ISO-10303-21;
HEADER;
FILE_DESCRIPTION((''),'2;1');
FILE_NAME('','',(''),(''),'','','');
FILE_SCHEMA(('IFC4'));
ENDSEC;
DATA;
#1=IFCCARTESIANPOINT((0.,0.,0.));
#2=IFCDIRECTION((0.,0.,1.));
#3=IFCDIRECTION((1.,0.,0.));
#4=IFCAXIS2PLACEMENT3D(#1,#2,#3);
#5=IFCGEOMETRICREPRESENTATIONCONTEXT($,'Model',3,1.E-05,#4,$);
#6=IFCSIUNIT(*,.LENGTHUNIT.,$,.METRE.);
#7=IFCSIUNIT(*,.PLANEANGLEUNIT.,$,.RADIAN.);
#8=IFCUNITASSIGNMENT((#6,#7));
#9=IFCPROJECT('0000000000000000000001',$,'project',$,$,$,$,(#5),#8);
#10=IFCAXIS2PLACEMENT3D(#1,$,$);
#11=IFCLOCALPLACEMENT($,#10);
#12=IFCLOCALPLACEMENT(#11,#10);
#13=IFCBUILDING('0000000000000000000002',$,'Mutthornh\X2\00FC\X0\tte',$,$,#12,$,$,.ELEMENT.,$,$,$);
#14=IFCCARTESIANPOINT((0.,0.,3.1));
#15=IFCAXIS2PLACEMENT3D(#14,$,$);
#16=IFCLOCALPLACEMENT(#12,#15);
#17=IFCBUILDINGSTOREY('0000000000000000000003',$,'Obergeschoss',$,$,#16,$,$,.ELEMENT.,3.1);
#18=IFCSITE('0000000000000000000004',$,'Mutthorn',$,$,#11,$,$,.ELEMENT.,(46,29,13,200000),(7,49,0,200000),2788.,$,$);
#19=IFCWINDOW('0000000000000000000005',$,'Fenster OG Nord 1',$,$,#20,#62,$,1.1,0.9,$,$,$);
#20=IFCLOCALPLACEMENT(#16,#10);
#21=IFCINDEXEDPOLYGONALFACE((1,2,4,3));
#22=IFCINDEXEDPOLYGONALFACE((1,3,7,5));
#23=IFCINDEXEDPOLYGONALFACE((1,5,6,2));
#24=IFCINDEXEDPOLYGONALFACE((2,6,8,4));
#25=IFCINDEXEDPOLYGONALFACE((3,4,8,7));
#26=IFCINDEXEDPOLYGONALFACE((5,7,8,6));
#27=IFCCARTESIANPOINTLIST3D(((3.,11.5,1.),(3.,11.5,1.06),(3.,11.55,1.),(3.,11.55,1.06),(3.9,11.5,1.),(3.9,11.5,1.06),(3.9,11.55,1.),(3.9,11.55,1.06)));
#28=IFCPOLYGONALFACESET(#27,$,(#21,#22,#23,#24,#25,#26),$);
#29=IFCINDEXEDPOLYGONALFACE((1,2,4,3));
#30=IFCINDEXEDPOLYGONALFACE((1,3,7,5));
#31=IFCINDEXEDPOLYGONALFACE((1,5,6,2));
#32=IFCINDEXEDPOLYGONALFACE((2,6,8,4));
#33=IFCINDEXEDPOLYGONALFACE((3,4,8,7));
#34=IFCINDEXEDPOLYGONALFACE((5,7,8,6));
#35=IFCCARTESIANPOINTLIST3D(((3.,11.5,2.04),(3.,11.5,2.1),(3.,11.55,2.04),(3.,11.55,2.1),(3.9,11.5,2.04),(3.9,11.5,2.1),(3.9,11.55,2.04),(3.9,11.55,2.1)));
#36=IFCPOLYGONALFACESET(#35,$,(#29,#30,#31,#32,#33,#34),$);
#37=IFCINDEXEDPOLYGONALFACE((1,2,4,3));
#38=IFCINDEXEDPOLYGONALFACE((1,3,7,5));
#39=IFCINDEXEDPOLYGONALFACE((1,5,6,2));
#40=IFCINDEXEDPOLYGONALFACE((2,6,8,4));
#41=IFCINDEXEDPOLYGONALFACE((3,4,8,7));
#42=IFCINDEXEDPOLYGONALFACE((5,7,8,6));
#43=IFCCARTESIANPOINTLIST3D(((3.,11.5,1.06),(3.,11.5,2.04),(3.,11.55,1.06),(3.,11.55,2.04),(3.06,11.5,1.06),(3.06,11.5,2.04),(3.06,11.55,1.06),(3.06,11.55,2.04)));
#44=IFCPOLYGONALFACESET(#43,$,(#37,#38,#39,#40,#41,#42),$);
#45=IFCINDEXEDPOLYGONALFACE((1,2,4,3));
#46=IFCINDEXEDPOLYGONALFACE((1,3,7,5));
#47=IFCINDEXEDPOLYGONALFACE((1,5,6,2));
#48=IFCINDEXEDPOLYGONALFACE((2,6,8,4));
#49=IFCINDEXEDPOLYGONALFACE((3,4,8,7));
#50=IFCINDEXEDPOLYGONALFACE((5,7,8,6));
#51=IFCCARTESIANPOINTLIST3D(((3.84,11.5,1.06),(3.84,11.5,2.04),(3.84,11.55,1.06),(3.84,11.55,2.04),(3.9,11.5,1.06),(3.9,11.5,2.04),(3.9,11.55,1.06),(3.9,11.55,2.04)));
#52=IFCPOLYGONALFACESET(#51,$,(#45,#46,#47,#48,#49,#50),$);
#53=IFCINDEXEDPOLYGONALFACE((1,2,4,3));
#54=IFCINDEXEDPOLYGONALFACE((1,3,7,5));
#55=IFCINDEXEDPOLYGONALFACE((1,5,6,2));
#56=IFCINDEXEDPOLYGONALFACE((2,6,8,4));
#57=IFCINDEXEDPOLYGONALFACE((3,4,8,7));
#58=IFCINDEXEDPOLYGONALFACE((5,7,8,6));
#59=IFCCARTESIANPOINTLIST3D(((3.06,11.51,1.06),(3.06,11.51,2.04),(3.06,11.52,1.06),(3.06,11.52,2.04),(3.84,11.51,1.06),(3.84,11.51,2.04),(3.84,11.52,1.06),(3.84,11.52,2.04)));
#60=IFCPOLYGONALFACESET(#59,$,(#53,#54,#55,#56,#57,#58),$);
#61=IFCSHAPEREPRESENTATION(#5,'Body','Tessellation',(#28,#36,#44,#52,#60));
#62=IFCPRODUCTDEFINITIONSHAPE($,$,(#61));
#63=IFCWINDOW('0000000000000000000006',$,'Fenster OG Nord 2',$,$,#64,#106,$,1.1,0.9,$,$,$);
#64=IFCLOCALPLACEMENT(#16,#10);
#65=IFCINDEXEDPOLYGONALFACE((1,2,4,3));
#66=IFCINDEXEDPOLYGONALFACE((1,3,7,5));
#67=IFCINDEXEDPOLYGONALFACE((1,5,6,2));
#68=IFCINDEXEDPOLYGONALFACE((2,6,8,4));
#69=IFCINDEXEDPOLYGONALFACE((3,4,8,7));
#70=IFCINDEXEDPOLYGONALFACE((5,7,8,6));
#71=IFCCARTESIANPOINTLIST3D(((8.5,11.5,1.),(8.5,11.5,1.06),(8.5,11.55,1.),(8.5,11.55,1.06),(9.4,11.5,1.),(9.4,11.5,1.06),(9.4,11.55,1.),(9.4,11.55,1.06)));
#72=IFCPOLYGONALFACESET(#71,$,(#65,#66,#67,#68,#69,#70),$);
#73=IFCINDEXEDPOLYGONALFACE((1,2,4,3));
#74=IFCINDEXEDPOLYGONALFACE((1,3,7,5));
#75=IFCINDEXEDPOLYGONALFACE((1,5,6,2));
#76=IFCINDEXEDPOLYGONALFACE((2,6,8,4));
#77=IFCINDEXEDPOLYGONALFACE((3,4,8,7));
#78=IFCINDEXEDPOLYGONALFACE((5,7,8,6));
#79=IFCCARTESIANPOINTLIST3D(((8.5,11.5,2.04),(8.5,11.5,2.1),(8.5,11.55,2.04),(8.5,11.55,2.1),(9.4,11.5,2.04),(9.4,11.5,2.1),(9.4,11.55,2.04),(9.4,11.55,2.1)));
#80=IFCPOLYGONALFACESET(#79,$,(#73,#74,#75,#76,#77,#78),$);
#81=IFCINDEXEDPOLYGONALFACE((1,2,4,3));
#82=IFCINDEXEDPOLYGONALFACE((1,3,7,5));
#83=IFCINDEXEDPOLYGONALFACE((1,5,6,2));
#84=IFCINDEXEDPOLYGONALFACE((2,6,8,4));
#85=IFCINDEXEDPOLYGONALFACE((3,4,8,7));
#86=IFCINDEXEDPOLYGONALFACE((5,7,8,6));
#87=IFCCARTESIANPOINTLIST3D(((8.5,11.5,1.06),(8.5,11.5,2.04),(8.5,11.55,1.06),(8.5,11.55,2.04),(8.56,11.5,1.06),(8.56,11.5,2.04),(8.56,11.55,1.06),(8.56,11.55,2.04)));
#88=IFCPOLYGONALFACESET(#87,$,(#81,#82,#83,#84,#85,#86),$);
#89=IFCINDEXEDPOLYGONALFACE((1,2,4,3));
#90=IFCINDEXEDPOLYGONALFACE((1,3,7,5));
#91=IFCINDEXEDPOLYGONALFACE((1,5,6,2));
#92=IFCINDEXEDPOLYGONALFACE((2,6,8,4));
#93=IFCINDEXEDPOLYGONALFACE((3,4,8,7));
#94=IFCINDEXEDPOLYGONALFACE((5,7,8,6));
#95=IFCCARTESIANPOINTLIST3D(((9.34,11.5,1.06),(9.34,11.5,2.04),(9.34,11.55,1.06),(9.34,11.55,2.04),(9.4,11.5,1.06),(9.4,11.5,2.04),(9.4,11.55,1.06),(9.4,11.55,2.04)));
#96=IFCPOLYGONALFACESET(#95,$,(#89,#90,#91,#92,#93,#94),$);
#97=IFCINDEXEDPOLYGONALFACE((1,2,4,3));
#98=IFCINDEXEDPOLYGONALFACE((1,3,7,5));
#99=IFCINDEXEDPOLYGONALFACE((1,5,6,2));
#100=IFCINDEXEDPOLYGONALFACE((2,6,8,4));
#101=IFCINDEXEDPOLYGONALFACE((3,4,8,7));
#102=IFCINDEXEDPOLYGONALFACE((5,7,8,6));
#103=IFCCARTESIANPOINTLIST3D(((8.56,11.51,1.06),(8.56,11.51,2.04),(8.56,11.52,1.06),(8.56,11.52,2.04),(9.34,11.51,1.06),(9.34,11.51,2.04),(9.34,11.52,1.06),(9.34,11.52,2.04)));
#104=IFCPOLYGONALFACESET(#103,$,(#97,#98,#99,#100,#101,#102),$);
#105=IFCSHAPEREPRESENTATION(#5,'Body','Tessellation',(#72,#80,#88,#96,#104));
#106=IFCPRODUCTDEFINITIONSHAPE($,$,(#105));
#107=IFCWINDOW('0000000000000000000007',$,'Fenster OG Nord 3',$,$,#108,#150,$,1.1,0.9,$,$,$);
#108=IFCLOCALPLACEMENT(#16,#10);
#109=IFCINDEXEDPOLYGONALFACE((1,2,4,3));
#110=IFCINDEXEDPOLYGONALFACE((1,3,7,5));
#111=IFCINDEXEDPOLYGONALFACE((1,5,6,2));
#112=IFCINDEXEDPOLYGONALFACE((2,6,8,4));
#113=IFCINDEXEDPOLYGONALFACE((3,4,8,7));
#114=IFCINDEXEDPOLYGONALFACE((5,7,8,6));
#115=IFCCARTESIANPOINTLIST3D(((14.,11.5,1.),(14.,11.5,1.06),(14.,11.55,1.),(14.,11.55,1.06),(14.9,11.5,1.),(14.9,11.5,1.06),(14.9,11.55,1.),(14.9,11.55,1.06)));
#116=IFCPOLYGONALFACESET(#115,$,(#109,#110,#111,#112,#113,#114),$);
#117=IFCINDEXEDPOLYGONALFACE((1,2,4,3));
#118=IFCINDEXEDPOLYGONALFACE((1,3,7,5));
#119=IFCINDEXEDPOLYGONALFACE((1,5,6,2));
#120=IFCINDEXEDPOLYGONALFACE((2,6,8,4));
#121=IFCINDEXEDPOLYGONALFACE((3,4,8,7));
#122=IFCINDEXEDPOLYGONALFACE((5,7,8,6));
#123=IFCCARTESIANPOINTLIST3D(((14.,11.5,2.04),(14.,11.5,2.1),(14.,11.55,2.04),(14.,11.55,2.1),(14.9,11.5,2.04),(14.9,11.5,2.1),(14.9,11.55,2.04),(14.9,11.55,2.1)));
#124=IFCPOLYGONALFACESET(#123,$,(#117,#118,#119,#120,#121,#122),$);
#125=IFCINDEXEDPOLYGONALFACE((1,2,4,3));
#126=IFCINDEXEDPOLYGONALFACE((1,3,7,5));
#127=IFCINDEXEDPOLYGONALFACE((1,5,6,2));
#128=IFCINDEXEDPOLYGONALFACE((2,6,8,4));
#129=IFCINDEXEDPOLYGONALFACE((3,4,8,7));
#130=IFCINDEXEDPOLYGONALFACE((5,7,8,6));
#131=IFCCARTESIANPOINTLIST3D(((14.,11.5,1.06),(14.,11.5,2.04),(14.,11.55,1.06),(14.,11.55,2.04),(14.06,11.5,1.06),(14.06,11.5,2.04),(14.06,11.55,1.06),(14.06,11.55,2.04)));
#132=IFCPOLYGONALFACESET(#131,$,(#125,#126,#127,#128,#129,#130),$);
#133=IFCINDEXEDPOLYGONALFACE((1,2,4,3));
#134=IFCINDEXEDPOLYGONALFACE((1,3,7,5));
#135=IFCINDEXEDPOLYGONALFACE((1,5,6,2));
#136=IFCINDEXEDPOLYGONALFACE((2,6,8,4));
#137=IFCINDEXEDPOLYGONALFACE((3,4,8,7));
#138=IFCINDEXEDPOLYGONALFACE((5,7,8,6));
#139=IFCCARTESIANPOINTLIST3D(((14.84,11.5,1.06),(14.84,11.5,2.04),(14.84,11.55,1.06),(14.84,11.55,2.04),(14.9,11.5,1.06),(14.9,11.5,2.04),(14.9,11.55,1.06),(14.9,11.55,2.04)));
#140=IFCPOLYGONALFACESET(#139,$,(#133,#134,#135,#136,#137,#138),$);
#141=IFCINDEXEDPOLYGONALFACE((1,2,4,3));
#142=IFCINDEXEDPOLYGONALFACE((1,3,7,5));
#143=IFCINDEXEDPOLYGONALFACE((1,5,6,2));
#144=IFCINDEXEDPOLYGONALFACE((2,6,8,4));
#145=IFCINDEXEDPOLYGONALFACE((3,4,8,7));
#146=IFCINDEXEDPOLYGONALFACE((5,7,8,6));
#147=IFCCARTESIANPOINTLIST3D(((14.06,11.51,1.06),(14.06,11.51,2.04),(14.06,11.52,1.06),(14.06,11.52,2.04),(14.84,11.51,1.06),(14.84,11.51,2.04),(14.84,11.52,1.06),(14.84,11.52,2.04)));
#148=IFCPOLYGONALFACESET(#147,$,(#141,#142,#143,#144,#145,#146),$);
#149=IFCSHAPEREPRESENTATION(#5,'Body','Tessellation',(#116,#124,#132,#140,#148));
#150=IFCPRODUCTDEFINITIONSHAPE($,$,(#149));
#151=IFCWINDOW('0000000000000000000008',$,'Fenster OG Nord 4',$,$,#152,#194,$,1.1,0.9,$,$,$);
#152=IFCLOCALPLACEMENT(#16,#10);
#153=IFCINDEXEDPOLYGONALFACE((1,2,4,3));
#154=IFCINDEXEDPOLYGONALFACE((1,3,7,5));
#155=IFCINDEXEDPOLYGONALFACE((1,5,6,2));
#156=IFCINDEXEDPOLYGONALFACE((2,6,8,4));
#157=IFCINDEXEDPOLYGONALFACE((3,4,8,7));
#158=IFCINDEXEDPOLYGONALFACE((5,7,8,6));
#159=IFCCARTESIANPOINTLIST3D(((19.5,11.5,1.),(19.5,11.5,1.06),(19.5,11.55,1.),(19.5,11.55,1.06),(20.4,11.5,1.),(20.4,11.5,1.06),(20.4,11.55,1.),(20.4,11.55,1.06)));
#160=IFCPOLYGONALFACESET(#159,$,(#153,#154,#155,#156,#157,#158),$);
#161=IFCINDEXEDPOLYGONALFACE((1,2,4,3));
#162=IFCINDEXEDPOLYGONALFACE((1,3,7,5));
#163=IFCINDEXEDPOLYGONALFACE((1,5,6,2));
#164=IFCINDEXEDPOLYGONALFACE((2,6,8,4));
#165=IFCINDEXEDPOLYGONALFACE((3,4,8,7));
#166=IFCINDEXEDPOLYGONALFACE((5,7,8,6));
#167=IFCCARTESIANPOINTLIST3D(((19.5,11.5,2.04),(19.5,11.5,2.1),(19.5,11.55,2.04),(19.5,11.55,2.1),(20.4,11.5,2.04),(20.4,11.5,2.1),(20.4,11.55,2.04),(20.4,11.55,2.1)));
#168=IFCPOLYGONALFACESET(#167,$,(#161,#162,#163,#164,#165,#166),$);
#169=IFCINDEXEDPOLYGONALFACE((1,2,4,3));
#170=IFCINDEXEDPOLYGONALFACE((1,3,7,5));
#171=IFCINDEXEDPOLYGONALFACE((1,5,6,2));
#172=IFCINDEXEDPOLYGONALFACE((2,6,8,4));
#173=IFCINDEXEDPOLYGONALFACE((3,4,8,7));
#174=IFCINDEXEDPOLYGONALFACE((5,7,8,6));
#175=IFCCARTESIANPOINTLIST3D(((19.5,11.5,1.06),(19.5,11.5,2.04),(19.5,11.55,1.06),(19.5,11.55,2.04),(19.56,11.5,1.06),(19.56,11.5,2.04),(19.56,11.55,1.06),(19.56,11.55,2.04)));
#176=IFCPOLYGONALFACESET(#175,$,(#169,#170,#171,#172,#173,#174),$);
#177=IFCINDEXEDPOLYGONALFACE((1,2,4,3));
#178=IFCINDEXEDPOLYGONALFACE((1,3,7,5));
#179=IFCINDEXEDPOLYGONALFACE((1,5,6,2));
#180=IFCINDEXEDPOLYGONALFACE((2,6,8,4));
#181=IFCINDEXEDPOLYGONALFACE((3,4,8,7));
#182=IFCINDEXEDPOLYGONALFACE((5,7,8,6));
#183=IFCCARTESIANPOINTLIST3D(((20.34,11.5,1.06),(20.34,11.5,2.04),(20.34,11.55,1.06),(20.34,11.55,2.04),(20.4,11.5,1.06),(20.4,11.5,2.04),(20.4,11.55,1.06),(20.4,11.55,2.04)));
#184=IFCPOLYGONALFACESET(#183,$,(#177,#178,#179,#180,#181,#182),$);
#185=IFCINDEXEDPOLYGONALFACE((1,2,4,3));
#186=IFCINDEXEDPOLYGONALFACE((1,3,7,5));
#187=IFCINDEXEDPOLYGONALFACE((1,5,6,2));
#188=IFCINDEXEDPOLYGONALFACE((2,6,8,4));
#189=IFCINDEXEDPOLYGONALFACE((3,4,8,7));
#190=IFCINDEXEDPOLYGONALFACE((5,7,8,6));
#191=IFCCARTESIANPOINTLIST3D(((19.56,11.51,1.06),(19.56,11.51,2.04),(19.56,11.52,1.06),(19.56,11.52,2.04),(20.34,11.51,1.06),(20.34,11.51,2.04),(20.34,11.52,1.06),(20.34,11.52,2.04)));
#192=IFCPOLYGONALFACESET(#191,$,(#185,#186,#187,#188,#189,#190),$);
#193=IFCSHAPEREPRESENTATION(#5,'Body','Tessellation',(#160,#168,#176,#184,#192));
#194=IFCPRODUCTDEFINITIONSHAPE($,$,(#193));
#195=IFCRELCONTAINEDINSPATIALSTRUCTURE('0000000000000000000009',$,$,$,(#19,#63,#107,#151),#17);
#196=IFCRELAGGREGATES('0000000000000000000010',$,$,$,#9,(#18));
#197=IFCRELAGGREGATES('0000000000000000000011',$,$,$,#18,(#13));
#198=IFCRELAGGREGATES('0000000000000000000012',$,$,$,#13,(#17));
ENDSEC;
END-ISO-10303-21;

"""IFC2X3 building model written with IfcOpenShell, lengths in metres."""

from ifc_helpers import new_model, si_unit, frame, frame_2d, origin, origin_with_axes, place, context, project, spatial, rectangle, extrude, element, save


model = new_model("IFC2X3")

# Units and contexts
model_context = context("Model", 3, precision=1e-05, world=origin_with_axes())
ifc_project = project(units=[si_unit("LENGTHUNIT", "METRE"), si_unit("PLANEANGLEUNIT", "RADIAN")], contexts=[model_context])

# Site, building, storey
site_placement = place(None, origin())
site = spatial("IfcSite", under=ifc_project, at=site_placement, Name="Mutthorn", CompositionType="ELEMENT", RefLatitude=(46, 29, 13, 200000), RefLongitude=(7, 49, 0, 200000), RefElevation=2788.0)
building_placement = place(site_placement, origin())
building = spatial("IfcBuilding", under=site, at=building_placement, Name="Mutthornhütte", CompositionType="ELEMENT")
storey_placement = place(building_placement, frame((0.0, 0.0, 3.1)))
storey = spatial("IfcBuildingStorey", under=building, at=storey_placement, Name="Obergeschoss", CompositionType="ELEMENT", Elevation=3.1)

# Windows
window_1_placement = place(storey_placement, origin())
element("IfcWindow", 1, at=window_1_placement, inside=storey, Name="Fenster OG Nord 1", OverallHeight=1.1, OverallWidth=0.9, context=model_context, shape_type="SweptSolid", body=[
    extrude(rectangle(XDim=0.9, YDim=0.05, at=frame_2d((0.45, 0.025))), frame((3.0, 11.5, 1.0)), (0.0, 0.0, 1.0), 0.06),
    extrude(rectangle(XDim=0.9, YDim=0.05, at=frame_2d((0.45, 0.025))), frame((3.0, 11.5, 2.04)), (0.0, 0.0, 1.0), 0.06),
    extrude(rectangle(XDim=0.06, YDim=0.05, at=frame_2d((0.03, 0.025))), frame((3.0, 11.5, 1.06)), (0.0, 0.0, 1.0), 0.98),
    extrude(rectangle(XDim=0.06, YDim=0.05, at=frame_2d((0.03, 0.025))), frame((3.84, 11.5, 1.06)), (0.0, 0.0, 1.0), 0.98),
    extrude(rectangle(XDim=0.78, YDim=0.01, at=frame_2d((0.39, 0.005))), frame((3.06, 11.51, 1.06)), (0.0, 0.0, 1.0), 0.98),
])
window_2_placement = place(storey_placement, origin())
element("IfcWindow", 2, at=window_2_placement, inside=storey, Name="Fenster OG Nord 2", OverallHeight=1.1, OverallWidth=0.9, context=model_context, shape_type="SweptSolid", body=[
    extrude(rectangle(XDim=0.9, YDim=0.05, at=frame_2d((0.45, 0.025))), frame((8.5, 11.5, 1.0)), (0.0, 0.0, 1.0), 0.06),
    extrude(rectangle(XDim=0.9, YDim=0.05, at=frame_2d((0.45, 0.025))), frame((8.5, 11.5, 2.04)), (0.0, 0.0, 1.0), 0.06),
    extrude(rectangle(XDim=0.06, YDim=0.05, at=frame_2d((0.03, 0.025))), frame((8.5, 11.5, 1.06)), (0.0, 0.0, 1.0), 0.98),
    extrude(rectangle(XDim=0.06, YDim=0.05, at=frame_2d((0.03, 0.025))), frame((9.34, 11.5, 1.06)), (0.0, 0.0, 1.0), 0.98),
    extrude(rectangle(XDim=0.78, YDim=0.01, at=frame_2d((0.39, 0.005))), frame((8.56, 11.51, 1.06)), (0.0, 0.0, 1.0), 0.98),
])
window_3_placement = place(storey_placement, origin())
element("IfcWindow", 3, at=window_3_placement, inside=storey, Name="Fenster OG Nord 3", OverallHeight=1.1, OverallWidth=0.9, context=model_context, shape_type="SweptSolid", body=[
    extrude(rectangle(XDim=0.9, YDim=0.05, at=frame_2d((0.45, 0.025))), frame((14.0, 11.5, 1.0)), (0.0, 0.0, 1.0), 0.06),
    extrude(rectangle(XDim=0.9, YDim=0.05, at=frame_2d((0.45, 0.025))), frame((14.0, 11.5, 2.04)), (0.0, 0.0, 1.0), 0.06),
    extrude(rectangle(XDim=0.06, YDim=0.05, at=frame_2d((0.03, 0.025))), frame((14.0, 11.5, 1.06)), (0.0, 0.0, 1.0), 0.98),
    extrude(rectangle(XDim=0.06, YDim=0.05, at=frame_2d((0.03, 0.025))), frame((14.84, 11.5, 1.06)), (0.0, 0.0, 1.0), 0.98),
    extrude(rectangle(XDim=0.78, YDim=0.01, at=frame_2d((0.39, 0.005))), frame((14.06, 11.51, 1.06)), (0.0, 0.0, 1.0), 0.98),
])
window_4_placement = place(storey_placement, origin())
element("IfcWindow", 4, at=window_4_placement, inside=storey, Name="Fenster OG Nord 4", OverallHeight=1.1, OverallWidth=0.9, context=model_context, shape_type="SweptSolid", body=[
    extrude(rectangle(XDim=0.9, YDim=0.05, at=frame_2d((0.45, 0.025))), frame((19.5, 11.5, 1.0)), (0.0, 0.0, 1.0), 0.06),
    extrude(rectangle(XDim=0.9, YDim=0.05, at=frame_2d((0.45, 0.025))), frame((19.5, 11.5, 2.04)), (0.0, 0.0, 1.0), 0.06),
    extrude(rectangle(XDim=0.06, YDim=0.05, at=frame_2d((0.03, 0.025))), frame((19.5, 11.5, 1.06)), (0.0, 0.0, 1.0), 0.98),
    extrude(rectangle(XDim=0.06, YDim=0.05, at=frame_2d((0.03, 0.025))), frame((20.34, 11.5, 1.06)), (0.0, 0.0, 1.0), 0.98),
    extrude(rectangle(XDim=0.78, YDim=0.01, at=frame_2d((0.39, 0.005))), frame((19.56, 11.51, 1.06)), (0.0, 0.0, 1.0), 0.98),
])

save(model, "model.ifc")
